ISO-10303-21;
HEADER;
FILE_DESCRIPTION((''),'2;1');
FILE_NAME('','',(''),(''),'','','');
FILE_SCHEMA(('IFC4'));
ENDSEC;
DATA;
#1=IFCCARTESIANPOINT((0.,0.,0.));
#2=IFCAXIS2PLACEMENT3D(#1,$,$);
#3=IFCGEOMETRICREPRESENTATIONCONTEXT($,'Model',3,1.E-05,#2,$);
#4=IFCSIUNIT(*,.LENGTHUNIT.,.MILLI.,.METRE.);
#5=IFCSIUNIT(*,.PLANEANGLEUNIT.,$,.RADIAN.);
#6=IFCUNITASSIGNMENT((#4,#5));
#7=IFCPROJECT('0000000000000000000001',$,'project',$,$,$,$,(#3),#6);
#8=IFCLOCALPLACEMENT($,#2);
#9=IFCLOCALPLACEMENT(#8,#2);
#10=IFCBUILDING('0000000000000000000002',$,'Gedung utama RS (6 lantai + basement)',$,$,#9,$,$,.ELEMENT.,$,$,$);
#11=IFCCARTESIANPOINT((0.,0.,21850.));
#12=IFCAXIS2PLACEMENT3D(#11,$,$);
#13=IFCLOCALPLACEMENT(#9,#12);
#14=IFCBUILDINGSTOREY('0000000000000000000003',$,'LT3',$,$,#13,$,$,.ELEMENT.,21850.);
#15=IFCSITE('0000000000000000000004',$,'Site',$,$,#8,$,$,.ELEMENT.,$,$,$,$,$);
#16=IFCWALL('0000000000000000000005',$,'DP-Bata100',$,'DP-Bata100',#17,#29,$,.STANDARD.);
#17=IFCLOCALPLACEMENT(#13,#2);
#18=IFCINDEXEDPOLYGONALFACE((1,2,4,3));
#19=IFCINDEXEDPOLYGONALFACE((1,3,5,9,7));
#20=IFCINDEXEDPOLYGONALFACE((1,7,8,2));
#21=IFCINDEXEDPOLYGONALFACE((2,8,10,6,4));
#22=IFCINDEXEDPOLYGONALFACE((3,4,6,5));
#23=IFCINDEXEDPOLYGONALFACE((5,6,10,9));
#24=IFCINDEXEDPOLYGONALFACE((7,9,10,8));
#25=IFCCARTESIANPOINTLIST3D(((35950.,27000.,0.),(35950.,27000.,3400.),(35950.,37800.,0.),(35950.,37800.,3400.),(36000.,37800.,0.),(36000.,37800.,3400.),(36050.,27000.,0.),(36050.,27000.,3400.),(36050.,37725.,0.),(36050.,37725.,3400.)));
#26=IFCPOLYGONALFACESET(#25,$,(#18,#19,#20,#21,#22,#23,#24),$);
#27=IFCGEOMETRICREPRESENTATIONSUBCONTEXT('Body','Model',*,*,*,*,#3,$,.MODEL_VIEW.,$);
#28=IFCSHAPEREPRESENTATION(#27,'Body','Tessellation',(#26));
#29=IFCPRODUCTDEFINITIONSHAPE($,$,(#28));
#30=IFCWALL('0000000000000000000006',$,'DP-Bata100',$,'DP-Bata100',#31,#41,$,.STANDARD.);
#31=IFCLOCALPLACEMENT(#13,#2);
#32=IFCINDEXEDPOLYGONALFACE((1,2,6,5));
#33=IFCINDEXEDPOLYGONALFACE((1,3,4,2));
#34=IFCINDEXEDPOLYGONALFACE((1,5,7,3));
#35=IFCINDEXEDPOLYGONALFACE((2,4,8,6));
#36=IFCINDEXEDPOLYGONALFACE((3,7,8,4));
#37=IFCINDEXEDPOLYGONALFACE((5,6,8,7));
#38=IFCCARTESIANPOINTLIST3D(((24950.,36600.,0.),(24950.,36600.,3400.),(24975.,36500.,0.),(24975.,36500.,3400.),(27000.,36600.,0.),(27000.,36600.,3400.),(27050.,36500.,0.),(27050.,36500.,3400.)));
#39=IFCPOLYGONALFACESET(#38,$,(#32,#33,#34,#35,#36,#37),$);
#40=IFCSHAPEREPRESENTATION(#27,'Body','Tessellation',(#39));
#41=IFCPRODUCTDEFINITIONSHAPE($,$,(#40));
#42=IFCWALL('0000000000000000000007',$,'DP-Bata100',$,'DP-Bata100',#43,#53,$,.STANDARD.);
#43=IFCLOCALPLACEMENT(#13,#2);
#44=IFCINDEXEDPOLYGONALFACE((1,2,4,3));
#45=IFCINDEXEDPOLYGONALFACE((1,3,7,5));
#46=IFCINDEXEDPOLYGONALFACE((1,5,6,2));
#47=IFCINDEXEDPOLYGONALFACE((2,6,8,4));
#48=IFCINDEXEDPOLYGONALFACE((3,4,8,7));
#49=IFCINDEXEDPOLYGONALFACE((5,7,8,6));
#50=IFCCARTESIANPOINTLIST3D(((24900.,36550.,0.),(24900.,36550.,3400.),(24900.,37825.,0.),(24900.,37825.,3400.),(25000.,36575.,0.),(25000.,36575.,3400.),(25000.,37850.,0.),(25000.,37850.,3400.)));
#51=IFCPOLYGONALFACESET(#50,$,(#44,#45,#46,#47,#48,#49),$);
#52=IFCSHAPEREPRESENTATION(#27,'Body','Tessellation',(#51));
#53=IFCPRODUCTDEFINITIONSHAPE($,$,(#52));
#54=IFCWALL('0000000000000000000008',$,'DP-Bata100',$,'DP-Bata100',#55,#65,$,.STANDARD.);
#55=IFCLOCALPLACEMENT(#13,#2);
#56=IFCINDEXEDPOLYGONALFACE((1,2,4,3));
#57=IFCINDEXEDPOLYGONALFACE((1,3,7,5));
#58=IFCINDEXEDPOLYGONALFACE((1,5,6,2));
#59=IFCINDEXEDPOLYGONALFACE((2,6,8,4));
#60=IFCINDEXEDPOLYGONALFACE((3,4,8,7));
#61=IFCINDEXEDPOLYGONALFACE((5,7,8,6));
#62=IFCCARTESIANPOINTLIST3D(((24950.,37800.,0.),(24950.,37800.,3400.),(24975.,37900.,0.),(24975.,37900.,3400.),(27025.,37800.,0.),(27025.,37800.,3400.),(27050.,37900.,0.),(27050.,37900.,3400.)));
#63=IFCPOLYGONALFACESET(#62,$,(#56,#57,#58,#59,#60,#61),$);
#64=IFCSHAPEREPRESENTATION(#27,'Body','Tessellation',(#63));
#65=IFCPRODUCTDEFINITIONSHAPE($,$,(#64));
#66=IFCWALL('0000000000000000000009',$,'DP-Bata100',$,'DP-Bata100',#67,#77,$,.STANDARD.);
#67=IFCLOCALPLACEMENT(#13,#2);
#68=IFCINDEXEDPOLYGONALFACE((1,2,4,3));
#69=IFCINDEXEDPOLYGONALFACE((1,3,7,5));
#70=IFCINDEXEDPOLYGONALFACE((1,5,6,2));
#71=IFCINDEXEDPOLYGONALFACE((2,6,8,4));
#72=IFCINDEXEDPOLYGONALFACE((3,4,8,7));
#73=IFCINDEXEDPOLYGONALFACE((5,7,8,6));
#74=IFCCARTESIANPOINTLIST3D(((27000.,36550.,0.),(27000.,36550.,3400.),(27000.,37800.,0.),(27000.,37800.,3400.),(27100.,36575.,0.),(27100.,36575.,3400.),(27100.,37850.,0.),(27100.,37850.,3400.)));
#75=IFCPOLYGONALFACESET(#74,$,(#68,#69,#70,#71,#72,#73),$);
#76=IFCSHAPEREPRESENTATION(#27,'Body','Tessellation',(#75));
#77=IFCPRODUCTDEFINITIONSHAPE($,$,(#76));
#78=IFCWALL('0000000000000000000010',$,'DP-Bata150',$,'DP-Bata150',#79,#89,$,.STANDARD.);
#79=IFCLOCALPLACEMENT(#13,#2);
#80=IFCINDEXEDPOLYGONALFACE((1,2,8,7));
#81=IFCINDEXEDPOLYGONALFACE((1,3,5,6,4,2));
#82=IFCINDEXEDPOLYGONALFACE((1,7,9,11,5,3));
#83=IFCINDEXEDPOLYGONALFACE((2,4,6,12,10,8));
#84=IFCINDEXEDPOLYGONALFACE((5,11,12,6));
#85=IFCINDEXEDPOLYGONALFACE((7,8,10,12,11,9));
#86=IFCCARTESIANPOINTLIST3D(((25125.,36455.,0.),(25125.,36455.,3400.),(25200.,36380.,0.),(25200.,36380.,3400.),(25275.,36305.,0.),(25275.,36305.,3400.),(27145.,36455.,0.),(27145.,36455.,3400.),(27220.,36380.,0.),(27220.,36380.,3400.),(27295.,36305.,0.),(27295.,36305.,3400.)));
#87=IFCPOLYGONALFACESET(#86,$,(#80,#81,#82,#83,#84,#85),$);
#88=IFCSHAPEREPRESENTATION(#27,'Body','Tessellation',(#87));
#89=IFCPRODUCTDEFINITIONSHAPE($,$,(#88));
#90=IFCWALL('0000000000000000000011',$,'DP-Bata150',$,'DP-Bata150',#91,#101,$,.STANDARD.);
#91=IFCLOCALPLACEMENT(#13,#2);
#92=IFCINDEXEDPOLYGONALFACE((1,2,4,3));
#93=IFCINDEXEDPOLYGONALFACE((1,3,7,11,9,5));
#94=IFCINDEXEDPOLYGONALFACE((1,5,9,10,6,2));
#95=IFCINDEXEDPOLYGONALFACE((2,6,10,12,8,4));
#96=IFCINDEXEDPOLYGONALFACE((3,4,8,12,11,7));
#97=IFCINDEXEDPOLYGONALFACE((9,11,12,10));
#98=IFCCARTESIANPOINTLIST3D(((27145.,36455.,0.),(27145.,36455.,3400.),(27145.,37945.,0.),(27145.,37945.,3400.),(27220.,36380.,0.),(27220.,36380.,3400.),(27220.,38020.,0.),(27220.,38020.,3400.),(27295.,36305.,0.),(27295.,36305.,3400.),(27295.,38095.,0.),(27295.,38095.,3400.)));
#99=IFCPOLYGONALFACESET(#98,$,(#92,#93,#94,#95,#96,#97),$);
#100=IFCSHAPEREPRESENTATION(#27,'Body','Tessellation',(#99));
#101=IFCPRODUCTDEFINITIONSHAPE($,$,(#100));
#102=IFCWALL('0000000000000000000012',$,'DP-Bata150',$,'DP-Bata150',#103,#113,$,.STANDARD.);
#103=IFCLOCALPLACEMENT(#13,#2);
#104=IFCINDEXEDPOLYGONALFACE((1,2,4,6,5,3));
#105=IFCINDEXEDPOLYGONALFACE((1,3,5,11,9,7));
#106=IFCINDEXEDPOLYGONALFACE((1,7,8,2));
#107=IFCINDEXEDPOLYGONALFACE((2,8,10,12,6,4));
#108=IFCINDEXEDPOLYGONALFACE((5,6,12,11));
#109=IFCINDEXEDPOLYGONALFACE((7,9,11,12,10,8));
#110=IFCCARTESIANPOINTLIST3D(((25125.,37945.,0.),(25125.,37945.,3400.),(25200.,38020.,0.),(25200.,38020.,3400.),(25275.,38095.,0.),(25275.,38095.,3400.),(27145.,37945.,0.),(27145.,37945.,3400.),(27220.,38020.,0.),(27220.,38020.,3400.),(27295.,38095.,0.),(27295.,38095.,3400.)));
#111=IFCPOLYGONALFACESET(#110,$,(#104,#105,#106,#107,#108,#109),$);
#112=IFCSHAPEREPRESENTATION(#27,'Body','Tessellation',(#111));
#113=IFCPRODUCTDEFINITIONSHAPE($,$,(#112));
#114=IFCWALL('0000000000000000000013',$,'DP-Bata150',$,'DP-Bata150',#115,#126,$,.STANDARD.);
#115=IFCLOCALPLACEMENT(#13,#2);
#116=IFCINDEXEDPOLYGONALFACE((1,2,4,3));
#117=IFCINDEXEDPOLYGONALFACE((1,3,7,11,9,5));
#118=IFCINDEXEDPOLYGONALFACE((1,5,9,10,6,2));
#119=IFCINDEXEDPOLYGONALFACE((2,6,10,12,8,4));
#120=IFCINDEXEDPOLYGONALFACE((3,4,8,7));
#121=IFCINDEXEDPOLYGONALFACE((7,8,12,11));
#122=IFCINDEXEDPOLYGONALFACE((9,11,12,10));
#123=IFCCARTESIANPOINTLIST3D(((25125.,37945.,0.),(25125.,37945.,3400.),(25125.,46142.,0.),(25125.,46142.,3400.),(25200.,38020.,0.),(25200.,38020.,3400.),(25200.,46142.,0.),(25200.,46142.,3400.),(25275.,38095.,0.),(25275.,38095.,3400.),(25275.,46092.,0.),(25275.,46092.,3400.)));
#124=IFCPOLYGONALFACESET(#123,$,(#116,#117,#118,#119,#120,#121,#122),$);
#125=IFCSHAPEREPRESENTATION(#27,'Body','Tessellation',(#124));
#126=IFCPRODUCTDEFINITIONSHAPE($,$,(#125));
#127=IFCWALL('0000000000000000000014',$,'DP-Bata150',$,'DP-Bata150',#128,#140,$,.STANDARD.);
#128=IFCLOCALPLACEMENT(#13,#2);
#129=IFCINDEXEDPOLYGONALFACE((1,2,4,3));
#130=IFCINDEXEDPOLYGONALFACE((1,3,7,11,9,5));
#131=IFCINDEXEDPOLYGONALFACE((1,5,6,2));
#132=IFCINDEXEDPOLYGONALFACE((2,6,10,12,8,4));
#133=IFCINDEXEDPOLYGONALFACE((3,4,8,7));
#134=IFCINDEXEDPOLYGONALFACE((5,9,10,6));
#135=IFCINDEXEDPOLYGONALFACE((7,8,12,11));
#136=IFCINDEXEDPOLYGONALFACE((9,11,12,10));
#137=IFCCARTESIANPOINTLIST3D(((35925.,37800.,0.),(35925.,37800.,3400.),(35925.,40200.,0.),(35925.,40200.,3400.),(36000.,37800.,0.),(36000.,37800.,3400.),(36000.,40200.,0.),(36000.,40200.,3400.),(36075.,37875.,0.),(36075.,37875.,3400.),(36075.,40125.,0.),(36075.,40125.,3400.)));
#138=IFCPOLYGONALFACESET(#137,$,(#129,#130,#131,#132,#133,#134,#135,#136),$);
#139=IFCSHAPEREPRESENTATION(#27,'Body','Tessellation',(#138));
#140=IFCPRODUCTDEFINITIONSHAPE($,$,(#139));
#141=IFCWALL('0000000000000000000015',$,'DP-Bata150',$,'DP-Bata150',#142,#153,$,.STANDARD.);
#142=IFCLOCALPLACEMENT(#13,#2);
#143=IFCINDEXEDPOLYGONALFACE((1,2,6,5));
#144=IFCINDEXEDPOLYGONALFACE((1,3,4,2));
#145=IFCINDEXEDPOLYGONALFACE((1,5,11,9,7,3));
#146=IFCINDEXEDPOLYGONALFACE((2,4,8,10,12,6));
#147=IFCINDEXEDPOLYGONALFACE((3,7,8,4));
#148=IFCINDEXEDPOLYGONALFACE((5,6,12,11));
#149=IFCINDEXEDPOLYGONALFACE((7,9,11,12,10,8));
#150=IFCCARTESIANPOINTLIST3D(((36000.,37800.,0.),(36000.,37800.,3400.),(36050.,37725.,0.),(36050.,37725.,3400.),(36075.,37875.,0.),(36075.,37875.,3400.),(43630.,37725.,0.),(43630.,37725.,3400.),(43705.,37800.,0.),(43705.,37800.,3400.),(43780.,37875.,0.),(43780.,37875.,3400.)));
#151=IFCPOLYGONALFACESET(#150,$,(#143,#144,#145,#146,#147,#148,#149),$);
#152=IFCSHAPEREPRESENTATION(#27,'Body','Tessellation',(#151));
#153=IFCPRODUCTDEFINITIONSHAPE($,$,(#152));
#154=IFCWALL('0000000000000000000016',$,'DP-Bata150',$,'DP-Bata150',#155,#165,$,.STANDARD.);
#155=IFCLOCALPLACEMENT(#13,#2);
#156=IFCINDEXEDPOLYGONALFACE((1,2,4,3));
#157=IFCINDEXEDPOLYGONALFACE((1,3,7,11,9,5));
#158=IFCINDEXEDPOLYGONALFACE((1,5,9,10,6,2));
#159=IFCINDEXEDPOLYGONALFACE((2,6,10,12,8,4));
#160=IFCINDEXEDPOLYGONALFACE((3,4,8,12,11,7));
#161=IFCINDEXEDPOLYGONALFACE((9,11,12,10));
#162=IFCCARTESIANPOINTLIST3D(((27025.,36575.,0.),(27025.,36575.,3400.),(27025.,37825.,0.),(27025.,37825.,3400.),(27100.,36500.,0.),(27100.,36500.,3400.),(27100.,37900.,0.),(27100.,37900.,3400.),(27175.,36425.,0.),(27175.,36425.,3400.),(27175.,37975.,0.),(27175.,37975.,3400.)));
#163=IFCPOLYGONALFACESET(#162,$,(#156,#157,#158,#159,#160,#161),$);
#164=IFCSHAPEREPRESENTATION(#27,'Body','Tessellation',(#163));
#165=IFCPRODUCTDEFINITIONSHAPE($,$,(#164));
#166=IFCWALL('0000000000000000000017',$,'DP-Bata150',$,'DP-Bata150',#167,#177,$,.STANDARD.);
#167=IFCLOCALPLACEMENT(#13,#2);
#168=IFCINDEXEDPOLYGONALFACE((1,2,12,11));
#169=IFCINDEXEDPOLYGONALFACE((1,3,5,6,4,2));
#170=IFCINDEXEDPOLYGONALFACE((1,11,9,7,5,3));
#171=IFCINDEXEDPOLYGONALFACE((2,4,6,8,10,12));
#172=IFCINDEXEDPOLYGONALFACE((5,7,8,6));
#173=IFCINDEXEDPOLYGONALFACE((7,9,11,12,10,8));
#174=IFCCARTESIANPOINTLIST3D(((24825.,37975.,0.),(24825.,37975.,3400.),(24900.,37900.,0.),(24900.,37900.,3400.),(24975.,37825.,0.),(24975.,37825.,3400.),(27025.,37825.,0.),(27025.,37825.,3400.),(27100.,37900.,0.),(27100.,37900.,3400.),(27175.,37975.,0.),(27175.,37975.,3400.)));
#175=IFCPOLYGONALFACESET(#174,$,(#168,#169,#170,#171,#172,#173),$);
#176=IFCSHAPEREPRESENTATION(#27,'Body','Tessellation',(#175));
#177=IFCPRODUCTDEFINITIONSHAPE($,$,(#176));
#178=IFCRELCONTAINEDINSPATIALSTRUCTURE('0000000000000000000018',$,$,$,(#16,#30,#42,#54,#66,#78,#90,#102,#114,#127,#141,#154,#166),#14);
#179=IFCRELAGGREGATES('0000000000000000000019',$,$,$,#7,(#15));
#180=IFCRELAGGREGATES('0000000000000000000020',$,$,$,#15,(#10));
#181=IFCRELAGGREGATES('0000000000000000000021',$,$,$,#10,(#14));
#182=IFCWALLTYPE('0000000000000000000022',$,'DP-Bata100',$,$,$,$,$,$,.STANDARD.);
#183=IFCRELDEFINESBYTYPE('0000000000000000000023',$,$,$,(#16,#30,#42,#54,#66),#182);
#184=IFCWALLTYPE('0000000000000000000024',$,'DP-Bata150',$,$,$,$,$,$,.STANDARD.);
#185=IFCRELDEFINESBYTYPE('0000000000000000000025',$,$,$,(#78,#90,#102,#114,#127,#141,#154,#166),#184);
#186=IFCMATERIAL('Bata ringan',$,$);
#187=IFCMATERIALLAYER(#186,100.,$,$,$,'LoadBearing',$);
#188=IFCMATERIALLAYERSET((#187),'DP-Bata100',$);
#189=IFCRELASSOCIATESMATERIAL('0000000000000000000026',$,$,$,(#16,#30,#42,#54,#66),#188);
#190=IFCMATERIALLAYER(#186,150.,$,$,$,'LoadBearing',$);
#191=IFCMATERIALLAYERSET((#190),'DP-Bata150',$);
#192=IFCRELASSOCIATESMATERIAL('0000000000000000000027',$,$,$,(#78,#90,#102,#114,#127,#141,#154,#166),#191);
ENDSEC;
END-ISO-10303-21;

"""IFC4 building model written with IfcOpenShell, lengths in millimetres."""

from ifc_helpers import new_model, si_unit, frame, origin, place, context, subcontext, project, spatial, polyline, outline, extrude, material, layer, layer_set, layer_usage, type_object, element, save


model = new_model("IFC4")

# Units and contexts
model_context = context("Model", 3, precision=1e-05, world=origin())
body_context = subcontext(model_context, "Body", "Model", "MODEL_VIEW")
ifc_project = project(units=[si_unit("LENGTHUNIT", "METRE", prefix="MILLI"), si_unit("PLANEANGLEUNIT", "RADIAN")], contexts=[model_context])

# Site, building, storey
site_placement = place(None, origin())
site = spatial("IfcSite", under=ifc_project, at=site_placement, Name="Site", CompositionType="ELEMENT")
building_placement = place(site_placement, origin())
building = spatial("IfcBuilding", under=site, at=building_placement, Name="Gedung utama RS (6 lantai + basement)", CompositionType="ELEMENT")
storey_placement = place(building_placement, frame((0.0, 0.0, 21850.0)))
storey = spatial("IfcBuildingStorey", under=building, at=storey_placement, Name="LT3", CompositionType="ELEMENT", Elevation=21850.0)

# Walls
ifc_material_1 = material(Name="Bata ringan")
ifc_layer_1 = layer(ifc_material_1, 100.0, Category="LoadBearing")
ifc_layer_set_1 = layer_set([ifc_layer_1], Name="DP-Bata100")
ifc_layer_usage_1 = layer_usage(ifc_layer_set_1, "AXIS2", "NEGATIVE", 50.0)
wall_type_1 = type_object("IfcWallType", Name="DP-Bata100", PredefinedType="STANDARD")
wall_1_placement = place(storey_placement, frame((36000.0, 37800.0, 0.0), z_axis=(0.0, 0.0, 1.0), x_axis=(0.0, -1.0, 0.0)))
element("IfcWall", 1, at=wall_1_placement, inside=storey, type_object=wall_type_1, material=ifc_layer_usage_1, Name="DP-Bata100", ObjectType="DP-Bata100", PredefinedType="STANDARD", context=body_context, shape_type="SweptSolid", body=[
    extrude(outline(polyline([(0.0, -50.0), (0.0, 0.0), (75.0, 50.0), (10800.0, 50.0), (10800.0, -50.0), (0.0, -50.0)])), origin(), (0.0, 0.0, 1.0), 3400.0),
])
wall_2_placement = place(storey_placement, frame((27050.0, 36550.0, 0.0), z_axis=(0.0, 0.0, 1.0), x_axis=(-1.0, 0.0, 0.0)))
element("IfcWall", 2, at=wall_2_placement, inside=storey, type_object=wall_type_1, material=ifc_layer_usage_1, Name="DP-Bata100", ObjectType="DP-Bata100", PredefinedType="STANDARD", context=body_context, shape_type="SweptSolid", body=[
    extrude(outline(polyline([(50.0, -50.0), (0.0, 50.0), (2075.0, 50.0), (2100.0, -50.0), (50.0, -50.0)])), origin(), (0.0, 0.0, 1.0), 3400.0),
])
wall_3_placement = place(storey_placement, frame((24950.0, 36550.0, 0.0), z_axis=(0.0, 0.0, 1.0), x_axis=(0.0, 1.0, 0.0)))
element("IfcWall", 3, at=wall_3_placement, inside=storey, type_object=wall_type_1, material=ifc_layer_usage_1, Name="DP-Bata100", ObjectType="DP-Bata100", PredefinedType="STANDARD", context=body_context, shape_type="SweptSolid", body=[
    extrude(outline(polyline([(25.0, -50.0), (0.0, 50.0), (1275.0, 50.0), (1300.0, -50.0), (25.0, -50.0)])), origin(), (0.0, 0.0, 1.0), 3400.0),
])
wall_4_placement = place(storey_placement, frame((24950.0, 37850.0, 0.0), z_axis=(0.0, 0.0, 1.0), x_axis=(1.0, 0.0, 0.0)))
element("IfcWall", 4, at=wall_4_placement, inside=storey, type_object=wall_type_1, material=ifc_layer_usage_1, Name="DP-Bata100", ObjectType="DP-Bata100", PredefinedType="STANDARD", context=body_context, shape_type="SweptSolid", body=[
    extrude(outline(polyline([(0.0, -50.0), (25.0, 50.0), (2100.0, 50.0), (2075.0, -50.0), (0.0, -50.0)])), origin(), (0.0, 0.0, 1.0), 3400.0),
])
wall_5_placement = place(storey_placement, frame((27050.0, 37850.0, 0.0), z_axis=(0.0, 0.0, 1.0), x_axis=(0.0, -1.0, 0.0)))
element("IfcWall", 5, at=wall_5_placement, inside=storey, type_object=wall_type_1, material=ifc_layer_usage_1, Name="DP-Bata100", ObjectType="DP-Bata100", PredefinedType="STANDARD", context=body_context, shape_type="SweptSolid", body=[
    extrude(outline(polyline([(50.0, -50.0), (0.0, 50.0), (1275.0, 50.0), (1300.0, -50.0), (50.0, -50.0)])), origin(), (0.0, 0.0, 1.0), 3400.0),
])
ifc_layer_2 = layer(ifc_material_1, 150.0, Category="LoadBearing")
ifc_layer_set_2 = layer_set([ifc_layer_2], Name="DP-Bata150")
ifc_layer_usage_2 = layer_usage(ifc_layer_set_2, "AXIS2", "NEGATIVE", 75.0)
wall_type_2 = type_object("IfcWallType", Name="DP-Bata150", PredefinedType="STANDARD")
wall_6_placement = place(storey_placement, frame((25200.0, 36380.0, 0.0), z_axis=(0.0, 0.0, 1.0), x_axis=(1.0, 0.0, 0.0)))
element("IfcWall", 6, at=wall_6_placement, inside=storey, type_object=wall_type_2, material=ifc_layer_usage_2, Name="DP-Bata150", ObjectType="DP-Bata150", PredefinedType="STANDARD", context=body_context, shape_type="SweptSolid", body=[
    extrude(outline(polyline([(75.0, -75.0), (0.0, 0.0), (-75.0, 75.0), (1945.0, 75.0), (2020.0, 0.0), (2095.0, -75.0), (75.0, -75.0)])), origin(), (0.0, 0.0, 1.0), 3400.0),
])
wall_7_placement = place(storey_placement, frame((27220.0, 36380.0, 0.0), z_axis=(0.0, 0.0, 1.0), x_axis=(0.0, 1.0, 0.0)))
element("IfcWall", 7, at=wall_7_placement, inside=storey, type_object=wall_type_2, material=ifc_layer_usage_2, Name="DP-Bata150", ObjectType="DP-Bata150", PredefinedType="STANDARD", context=body_context, shape_type="SweptSolid", body=[
    extrude(outline(polyline([(-75.0, -75.0), (0.0, 0.0), (75.0, 75.0), (1565.0, 75.0), (1640.0, 0.0), (1715.0, -75.0), (-75.0, -75.0)])), origin(), (0.0, 0.0, 1.0), 3400.0),
])
wall_8_placement = place(storey_placement, frame((27220.0, 38020.0, 0.0), z_axis=(0.0, 0.0, 1.0), x_axis=(-1.0, 0.0, 0.0)))
element("IfcWall", 8, at=wall_8_placement, inside=storey, type_object=wall_type_2, material=ifc_layer_usage_2, Name="DP-Bata150", ObjectType="DP-Bata150", PredefinedType="STANDARD", context=body_context, shape_type="SweptSolid", body=[
    extrude(outline(polyline([(-75.0, -75.0), (0.0, 0.0), (75.0, 75.0), (2095.0, 75.0), (2020.0, 0.0), (1945.0, -75.0), (-75.0, -75.0)])), origin(), (0.0, 0.0, 1.0), 3400.0),
])
wall_9_placement = place(storey_placement, frame((25200.0, 38020.0, 0.0), z_axis=(0.0, 0.0, 1.0), x_axis=(0.0, 1.0, 0.0)))
element("IfcWall", 9, at=wall_9_placement, inside=storey, type_object=wall_type_2, material=ifc_layer_usage_2, Name="DP-Bata150", ObjectType="DP-Bata150", PredefinedType="STANDARD", context=body_context, shape_type="SweptSolid", body=[
    extrude(outline(polyline([(75.0, -75.0), (0.0, 0.0), (-75.0, 75.0), (8122.0, 75.0), (8122.0, 0.0), (8072.0, -75.0), (75.0, -75.0)])), origin(), (0.0, 0.0, 1.0), 3400.0),
])
wall_10_placement = place(storey_placement, frame((36000.0, 40200.0, 0.0), z_axis=(0.0, 0.0, 1.0), x_axis=(0.0, -1.0, 0.0)))
element("IfcWall", 10, at=wall_10_placement, inside=storey, type_object=wall_type_2, material=ifc_layer_usage_2, Name="DP-Bata150", ObjectType="DP-Bata150", PredefinedType="STANDARD", context=body_context, shape_type="SweptSolid", body=[
    extrude(outline(polyline([(0.0, -75.0), (0.0, 0.0), (75.0, 75.0), (2325.0, 75.0), (2400.0, 0.0), (2400.0, -75.0), (0.0, -75.0)])), origin(), (0.0, 0.0, 1.0), 3400.0),
])
wall_11_placement = place(storey_placement, frame((36000.0, 37800.0, 0.0), z_axis=(0.0, 0.0, 1.0), x_axis=(1.0, 0.0, 0.0)))
element("IfcWall", 11, at=wall_11_placement, inside=storey, type_object=wall_type_2, material=ifc_layer_usage_2, Name="DP-Bata150", ObjectType="DP-Bata150", PredefinedType="STANDARD", context=body_context, shape_type="SweptSolid", body=[
    extrude(outline(polyline([(50.0, -75.0), (0.0, 0.0), (75.0, 75.0), (7780.0, 75.0), (7705.0, 0.0), (7630.0, -75.0), (50.0, -75.0)])), origin(), (0.0, 0.0, 1.0), 3400.0),
])
wall_12_placement = place(storey_placement, frame((27100.0, 36500.0, 0.0), z_axis=(0.0, 0.0, 1.0), x_axis=(0.0, 1.0, 0.0)))
element("IfcWall", 12, at=wall_12_placement, inside=storey, type_object=wall_type_2, material=ifc_layer_usage_2, Name="DP-Bata150", ObjectType="DP-Bata150", PredefinedType="STANDARD", context=body_context, shape_type="SweptSolid", body=[
    extrude(outline(polyline([(-75.0, -75.0), (0.0, 0.0), (75.0, 75.0), (1325.0, 75.0), (1400.0, 0.0), (1475.0, -75.0), (-75.0, -75.0)])), origin(), (0.0, 0.0, 1.0), 3400.0),
])
wall_13_placement = place(storey_placement, frame((27100.0, 37900.0, 0.0), z_axis=(0.0, 0.0, 1.0), x_axis=(-1.0, 0.0, 0.0)))
element("IfcWall", 13, at=wall_13_placement, inside=storey, type_object=wall_type_2, material=ifc_layer_usage_2, Name="DP-Bata150", ObjectType="DP-Bata150", PredefinedType="STANDARD", context=body_context, shape_type="SweptSolid", body=[
    extrude(outline(polyline([(-75.0, -75.0), (0.0, 0.0), (75.0, 75.0), (2125.0, 75.0), (2200.0, 0.0), (2275.0, -75.0), (-75.0, -75.0)])), origin(), (0.0, 0.0, 1.0), 3400.0),
])

save(model, "model.ifc")
